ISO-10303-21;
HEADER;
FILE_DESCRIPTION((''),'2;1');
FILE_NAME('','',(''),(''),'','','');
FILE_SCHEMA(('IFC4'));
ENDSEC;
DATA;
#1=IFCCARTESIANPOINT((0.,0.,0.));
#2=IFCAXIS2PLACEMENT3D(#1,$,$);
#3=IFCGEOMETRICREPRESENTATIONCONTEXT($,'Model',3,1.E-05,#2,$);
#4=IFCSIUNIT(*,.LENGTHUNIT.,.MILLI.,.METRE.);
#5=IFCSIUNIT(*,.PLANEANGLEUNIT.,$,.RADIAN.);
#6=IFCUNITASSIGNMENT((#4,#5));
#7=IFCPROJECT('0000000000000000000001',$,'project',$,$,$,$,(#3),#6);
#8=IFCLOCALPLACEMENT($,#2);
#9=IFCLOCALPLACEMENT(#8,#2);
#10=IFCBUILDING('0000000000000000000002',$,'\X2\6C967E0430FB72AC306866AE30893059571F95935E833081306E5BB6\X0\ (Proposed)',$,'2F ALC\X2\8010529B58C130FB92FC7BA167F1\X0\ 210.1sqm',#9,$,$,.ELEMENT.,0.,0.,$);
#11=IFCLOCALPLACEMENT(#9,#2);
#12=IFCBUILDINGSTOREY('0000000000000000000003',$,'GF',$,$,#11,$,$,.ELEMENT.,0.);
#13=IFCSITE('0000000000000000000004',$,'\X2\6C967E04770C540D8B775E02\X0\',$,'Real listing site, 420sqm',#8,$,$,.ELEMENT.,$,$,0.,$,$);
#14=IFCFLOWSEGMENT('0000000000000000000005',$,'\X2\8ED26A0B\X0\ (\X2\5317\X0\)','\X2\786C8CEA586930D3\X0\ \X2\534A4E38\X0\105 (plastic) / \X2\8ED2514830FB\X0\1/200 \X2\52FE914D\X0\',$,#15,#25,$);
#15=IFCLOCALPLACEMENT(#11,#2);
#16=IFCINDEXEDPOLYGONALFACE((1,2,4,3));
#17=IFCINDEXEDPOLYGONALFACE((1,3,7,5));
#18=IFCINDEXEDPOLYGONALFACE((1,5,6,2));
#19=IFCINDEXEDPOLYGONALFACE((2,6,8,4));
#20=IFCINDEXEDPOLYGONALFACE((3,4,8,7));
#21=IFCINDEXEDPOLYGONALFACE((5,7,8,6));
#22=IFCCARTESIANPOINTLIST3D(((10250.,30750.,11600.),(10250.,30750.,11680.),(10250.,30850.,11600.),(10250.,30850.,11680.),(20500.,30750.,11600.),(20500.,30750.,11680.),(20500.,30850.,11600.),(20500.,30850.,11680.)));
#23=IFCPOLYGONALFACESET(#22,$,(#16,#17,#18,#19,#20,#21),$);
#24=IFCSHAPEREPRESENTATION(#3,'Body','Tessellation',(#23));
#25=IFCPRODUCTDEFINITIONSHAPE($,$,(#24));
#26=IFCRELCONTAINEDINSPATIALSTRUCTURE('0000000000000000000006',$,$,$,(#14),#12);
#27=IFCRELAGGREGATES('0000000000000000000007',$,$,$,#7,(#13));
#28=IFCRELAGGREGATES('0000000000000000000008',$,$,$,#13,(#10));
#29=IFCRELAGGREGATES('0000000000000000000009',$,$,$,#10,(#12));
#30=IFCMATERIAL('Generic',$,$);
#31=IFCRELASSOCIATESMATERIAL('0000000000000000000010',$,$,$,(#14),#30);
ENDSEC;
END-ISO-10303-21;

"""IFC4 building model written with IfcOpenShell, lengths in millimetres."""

from ifc_helpers import new_model, si_unit, frame, frame_2d, origin, place, context, project, spatial, rectangle, extrude, material, element, save


model = new_model("IFC4")

# Units and contexts
model_context = context("Model", 3, precision=1e-05, world=origin())
ifc_project = project(units=[si_unit("LENGTHUNIT", "METRE", prefix="MILLI"), si_unit("PLANEANGLEUNIT", "RADIAN")], contexts=[model_context])

# Site, building, storey
site_placement = place(None, origin())
site = spatial("IfcSite", under=ifc_project, at=site_placement, Name="沖縄県名護市", ObjectType="Real listing site, 420sqm", CompositionType="ELEMENT", RefElevation=0.0)
building_placement = place(site_placement, origin())
building = spatial("IfcBuilding", under=site, at=building_placement, Name="沖縄・犬と暮らす土間広めの家 (Proposed)", ObjectType="2F ALC耐力壁・鋼管柱 210.1sqm", CompositionType="ELEMENT", ElevationOfRefHeight=0.0, ElevationOfTerrain=0.0)
storey_placement = place(building_placement, origin())
storey = spatial("IfcBuildingStorey", under=building, at=storey_placement, Name="GF", CompositionType="ELEMENT", Elevation=0.0)

# Flow segment
ifc_material_1 = material(Name="Generic")
flow_segment_1_placement = place(storey_placement, frame((5125.0, 15375.0, 5800.0)))
element("IfcFlowSegment", 1, at=flow_segment_1_placement, inside=storey, material=ifc_material_1, Name="軒樋 (北)", Description="硬質塩ビ 半丸105 (plastic) / 軒先・1/200 勾配", context=model_context, shape_type="SweptSolid", body=[
    extrude(rectangle(XDim=10250.0, YDim=100.0, at=frame_2d((5125.0, 50.0))), frame((5125.0, 15375.0, 5800.0)), (0.0, 0.0, 1.0), 80.0),
])

save(model, "model.ifc")
